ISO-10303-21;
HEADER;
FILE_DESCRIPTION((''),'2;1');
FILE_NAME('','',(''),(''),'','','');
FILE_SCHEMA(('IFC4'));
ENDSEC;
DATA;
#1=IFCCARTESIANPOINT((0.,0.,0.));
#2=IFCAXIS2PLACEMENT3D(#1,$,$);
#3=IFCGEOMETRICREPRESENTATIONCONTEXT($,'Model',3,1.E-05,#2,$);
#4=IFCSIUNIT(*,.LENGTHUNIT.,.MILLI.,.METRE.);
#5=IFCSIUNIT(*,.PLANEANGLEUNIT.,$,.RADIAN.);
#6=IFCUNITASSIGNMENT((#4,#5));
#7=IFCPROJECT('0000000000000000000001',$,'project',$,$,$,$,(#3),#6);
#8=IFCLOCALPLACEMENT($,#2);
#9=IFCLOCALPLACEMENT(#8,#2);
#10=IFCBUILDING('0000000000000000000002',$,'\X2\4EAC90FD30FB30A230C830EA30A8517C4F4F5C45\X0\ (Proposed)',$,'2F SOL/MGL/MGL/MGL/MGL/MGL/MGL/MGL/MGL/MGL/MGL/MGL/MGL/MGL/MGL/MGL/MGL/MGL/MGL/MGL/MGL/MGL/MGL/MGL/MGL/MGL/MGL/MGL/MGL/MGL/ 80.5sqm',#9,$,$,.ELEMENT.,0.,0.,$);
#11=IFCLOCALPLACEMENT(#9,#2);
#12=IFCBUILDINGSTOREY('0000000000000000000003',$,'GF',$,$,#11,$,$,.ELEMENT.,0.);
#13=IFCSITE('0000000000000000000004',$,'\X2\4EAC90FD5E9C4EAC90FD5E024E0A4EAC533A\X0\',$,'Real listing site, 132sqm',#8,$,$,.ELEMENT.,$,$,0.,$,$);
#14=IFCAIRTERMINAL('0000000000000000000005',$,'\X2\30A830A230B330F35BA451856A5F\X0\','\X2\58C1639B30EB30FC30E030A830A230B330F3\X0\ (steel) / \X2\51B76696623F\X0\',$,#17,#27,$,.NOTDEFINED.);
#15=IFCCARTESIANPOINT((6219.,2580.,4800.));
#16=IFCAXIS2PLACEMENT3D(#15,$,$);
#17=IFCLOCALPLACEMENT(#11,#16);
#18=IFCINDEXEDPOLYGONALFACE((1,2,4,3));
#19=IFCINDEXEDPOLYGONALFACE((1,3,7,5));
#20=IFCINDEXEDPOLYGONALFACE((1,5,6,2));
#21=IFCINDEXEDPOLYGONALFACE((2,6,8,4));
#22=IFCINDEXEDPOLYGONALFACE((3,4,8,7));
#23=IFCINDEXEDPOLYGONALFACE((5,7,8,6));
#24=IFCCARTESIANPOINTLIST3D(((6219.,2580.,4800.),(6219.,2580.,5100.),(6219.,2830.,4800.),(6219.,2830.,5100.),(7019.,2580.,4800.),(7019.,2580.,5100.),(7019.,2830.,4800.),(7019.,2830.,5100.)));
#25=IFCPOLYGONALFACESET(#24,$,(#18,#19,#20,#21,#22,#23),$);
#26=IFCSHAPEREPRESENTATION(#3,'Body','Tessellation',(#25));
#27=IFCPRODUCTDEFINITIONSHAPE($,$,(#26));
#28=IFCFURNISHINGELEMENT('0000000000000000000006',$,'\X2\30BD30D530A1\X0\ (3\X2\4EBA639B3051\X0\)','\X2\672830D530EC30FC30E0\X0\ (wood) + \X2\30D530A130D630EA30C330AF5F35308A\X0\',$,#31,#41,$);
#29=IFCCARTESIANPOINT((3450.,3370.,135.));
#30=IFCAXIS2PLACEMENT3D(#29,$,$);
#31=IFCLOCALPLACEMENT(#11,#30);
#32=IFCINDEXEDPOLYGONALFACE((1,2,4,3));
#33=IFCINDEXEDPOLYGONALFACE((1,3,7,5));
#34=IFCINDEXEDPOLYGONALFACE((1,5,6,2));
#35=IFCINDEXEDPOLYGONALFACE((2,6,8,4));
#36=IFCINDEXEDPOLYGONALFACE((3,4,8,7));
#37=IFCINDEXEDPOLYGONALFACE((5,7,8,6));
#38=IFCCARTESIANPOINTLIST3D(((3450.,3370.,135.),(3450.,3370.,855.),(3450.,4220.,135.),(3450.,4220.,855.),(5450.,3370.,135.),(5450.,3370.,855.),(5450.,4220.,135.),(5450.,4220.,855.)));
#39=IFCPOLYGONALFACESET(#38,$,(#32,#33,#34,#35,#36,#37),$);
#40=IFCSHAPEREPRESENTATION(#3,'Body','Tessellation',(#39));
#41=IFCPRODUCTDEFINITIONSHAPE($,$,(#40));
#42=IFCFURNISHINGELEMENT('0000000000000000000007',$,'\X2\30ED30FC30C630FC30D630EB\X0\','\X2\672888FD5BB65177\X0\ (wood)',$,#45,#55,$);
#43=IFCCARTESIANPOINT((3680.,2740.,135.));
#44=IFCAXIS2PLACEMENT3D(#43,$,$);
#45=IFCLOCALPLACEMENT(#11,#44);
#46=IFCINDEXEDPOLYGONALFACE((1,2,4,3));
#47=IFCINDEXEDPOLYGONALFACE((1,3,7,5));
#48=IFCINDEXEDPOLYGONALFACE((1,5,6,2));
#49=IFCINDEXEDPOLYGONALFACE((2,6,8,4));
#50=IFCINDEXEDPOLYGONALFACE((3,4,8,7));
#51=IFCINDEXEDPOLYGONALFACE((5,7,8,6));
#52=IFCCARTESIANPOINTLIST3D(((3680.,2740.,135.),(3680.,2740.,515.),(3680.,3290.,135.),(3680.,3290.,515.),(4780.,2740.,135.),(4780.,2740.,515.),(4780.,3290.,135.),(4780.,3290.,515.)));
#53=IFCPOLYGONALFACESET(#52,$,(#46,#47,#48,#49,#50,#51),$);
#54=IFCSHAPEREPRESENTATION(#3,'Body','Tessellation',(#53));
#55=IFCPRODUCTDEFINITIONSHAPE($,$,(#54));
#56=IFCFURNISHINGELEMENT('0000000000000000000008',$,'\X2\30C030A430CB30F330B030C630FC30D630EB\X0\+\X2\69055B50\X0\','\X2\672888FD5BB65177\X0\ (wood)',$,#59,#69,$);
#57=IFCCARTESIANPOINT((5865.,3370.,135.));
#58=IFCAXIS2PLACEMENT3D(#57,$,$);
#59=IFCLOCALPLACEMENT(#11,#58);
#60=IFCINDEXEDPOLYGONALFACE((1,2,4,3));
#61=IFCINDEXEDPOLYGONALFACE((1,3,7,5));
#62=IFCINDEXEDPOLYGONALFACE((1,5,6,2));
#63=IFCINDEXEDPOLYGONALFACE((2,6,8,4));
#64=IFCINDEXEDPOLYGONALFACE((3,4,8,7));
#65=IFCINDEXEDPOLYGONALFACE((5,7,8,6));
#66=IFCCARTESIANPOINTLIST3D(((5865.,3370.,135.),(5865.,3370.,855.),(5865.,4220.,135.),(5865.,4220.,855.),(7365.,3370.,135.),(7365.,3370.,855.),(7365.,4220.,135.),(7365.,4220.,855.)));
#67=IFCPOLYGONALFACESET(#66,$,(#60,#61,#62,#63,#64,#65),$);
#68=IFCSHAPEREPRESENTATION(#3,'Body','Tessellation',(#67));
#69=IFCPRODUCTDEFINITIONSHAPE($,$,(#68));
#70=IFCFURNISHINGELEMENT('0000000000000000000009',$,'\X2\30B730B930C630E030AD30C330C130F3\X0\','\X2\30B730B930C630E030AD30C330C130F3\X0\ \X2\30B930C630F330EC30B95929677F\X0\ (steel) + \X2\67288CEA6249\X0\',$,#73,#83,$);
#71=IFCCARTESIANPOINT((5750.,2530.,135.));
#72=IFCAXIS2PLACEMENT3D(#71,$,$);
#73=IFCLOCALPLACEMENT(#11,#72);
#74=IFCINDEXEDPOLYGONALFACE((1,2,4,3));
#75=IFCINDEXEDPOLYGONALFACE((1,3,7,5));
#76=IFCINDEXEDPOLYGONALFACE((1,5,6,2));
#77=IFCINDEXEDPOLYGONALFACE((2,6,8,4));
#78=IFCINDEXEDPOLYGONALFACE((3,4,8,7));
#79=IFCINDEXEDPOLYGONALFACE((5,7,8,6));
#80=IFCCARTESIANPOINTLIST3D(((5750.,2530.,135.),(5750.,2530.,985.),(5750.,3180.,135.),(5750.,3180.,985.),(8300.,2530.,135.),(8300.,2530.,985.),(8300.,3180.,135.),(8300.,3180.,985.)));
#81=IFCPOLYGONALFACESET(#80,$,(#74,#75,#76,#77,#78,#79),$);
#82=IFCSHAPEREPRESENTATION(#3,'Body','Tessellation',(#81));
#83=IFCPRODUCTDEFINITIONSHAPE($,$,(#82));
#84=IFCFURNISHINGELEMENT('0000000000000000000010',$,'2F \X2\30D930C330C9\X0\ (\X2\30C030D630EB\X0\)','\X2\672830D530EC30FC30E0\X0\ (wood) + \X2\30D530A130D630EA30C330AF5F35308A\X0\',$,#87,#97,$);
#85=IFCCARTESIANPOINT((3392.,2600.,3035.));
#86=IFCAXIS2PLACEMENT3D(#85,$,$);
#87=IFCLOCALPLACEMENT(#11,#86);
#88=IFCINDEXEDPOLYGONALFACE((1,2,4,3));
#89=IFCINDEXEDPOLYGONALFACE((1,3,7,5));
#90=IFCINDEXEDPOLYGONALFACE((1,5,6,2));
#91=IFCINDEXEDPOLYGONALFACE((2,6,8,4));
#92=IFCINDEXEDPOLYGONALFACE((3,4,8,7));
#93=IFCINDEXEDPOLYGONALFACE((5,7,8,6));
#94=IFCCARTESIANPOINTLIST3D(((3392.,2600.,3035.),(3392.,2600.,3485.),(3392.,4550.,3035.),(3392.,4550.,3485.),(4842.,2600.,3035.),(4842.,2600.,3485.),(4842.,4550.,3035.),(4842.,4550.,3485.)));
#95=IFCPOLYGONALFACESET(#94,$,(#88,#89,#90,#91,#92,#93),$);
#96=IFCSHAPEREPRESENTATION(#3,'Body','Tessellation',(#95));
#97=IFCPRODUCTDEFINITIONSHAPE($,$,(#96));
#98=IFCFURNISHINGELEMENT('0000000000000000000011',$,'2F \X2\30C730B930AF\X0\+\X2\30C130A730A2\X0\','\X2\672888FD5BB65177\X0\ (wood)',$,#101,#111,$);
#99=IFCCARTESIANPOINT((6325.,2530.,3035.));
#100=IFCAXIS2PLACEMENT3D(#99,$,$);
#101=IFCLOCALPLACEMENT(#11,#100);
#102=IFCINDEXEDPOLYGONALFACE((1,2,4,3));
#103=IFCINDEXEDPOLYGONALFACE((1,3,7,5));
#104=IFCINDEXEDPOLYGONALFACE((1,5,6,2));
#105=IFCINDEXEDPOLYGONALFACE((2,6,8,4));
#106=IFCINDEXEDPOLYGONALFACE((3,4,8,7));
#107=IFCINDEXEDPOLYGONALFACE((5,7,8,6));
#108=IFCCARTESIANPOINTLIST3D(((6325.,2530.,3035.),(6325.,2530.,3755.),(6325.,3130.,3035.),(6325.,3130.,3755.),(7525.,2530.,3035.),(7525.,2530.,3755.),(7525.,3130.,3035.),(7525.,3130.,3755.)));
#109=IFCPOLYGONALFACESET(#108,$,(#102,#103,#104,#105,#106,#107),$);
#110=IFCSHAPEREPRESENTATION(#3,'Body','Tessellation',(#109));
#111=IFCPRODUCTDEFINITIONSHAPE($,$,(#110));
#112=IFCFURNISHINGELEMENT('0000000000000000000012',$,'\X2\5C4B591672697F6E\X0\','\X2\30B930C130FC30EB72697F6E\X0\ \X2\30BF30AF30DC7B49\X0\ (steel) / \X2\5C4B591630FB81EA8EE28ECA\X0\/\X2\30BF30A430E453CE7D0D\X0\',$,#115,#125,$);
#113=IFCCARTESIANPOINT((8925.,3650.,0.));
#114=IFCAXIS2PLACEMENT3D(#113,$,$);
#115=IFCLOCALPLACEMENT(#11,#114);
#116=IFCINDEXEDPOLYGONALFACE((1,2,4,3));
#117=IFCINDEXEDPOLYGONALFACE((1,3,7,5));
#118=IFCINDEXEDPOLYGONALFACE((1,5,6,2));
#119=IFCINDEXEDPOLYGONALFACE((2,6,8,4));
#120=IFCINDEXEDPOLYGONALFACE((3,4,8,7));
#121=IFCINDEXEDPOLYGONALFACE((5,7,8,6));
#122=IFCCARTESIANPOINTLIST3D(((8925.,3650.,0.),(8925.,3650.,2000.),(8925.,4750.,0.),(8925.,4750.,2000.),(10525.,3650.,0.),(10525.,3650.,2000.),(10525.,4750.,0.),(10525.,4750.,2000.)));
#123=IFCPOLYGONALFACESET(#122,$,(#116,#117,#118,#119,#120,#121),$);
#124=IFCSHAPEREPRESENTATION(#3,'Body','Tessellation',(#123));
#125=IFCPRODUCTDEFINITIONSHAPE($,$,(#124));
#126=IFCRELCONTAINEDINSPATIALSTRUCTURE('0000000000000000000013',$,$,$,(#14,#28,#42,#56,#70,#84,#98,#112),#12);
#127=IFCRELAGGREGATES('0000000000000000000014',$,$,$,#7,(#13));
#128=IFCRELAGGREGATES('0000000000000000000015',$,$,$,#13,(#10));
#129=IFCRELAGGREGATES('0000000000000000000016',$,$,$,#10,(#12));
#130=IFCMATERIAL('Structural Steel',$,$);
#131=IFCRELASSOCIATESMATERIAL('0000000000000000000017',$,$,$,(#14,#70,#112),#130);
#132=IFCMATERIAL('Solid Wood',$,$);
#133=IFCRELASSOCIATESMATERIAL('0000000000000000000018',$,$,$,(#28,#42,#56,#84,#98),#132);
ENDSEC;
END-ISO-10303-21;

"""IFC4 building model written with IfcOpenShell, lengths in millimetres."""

from ifc_helpers import new_model, si_unit, frame, frame_2d, origin, place, context, project, spatial, rectangle, extrude, material, element, save


model = new_model("IFC4")

# Units and contexts
model_context = context("Model", 3, precision=1e-05, world=origin())
ifc_project = project(units=[si_unit("LENGTHUNIT", "METRE", prefix="MILLI"), si_unit("PLANEANGLEUNIT", "RADIAN")], contexts=[model_context])

# Site, building, storey
site_placement = place(None, origin())
site = spatial("IfcSite", under=ifc_project, at=site_placement, Name="京都府京都市上京区", ObjectType="Real listing site, 132sqm", CompositionType="ELEMENT", RefElevation=0.0)
building_placement = place(site_placement, origin())
building = spatial("IfcBuilding", under=site, at=building_placement, Name="京都・アトリエ兼住居 (Proposed)", ObjectType="2F SOL/MGL/MGL/MGL/MGL/MGL/MGL/MGL/MGL/MGL/MGL/MGL/MGL/MGL/MGL/MGL/MGL/MGL/MGL/MGL/MGL/MGL/MGL/MGL/MGL/MGL/MGL/MGL/MGL/MGL/ 80.5sqm", CompositionType="ELEMENT", ElevationOfRefHeight=0.0, ElevationOfTerrain=0.0)
storey_placement = place(building_placement, origin())
storey = spatial("IfcBuildingStorey", under=building, at=storey_placement, Name="GF", CompositionType="ELEMENT", Elevation=0.0)

# Shared definitions
ifc_material_1 = material(Name="Solid Wood")

# Shared definitions
ifc_material_2 = material(Name="Structural Steel")

# Air terminal
air_terminal_1_placement = place(storey_placement, frame((6219.0, 2580.0, 4800.0)))
element("IfcAirTerminal", 1, at=air_terminal_1_placement, inside=storey, material=ifc_material_2, Name="エアコン室内機", Description="壁掛ルームエアコン (steel) / 冷暖房", PredefinedType="NOTDEFINED", context=model_context, shape_type="SweptSolid", body=[
    extrude(rectangle(XDim=800.0, YDim=250.0, at=frame_2d((400.0, 125.0))), frame((6219.0, 2580.0, 4800.0)), (0.0, 0.0, 1.0), 300.0),
])

# Furnishing elements
furnishing_1_placement = place(storey_placement, frame((3450.0, 3370.0, 135.0)))
element("IfcFurnishingElement", 2, at=furnishing_1_placement, inside=storey, material=ifc_material_1, Name="ソファ (3人掛け)", Description="木フレーム (wood) + ファブリック張り", context=model_context, shape_type="SweptSolid", body=[
    extrude(rectangle(XDim=2000.0, YDim=850.0, at=frame_2d((1000.0, 425.0))), frame((3450.0, 3370.0, 135.0)), (0.0, 0.0, 1.0), 720.0),
])
furnishing_2_placement = place(storey_placement, frame((3680.0, 2740.0, 135.0)))
element("IfcFurnishingElement", 3, at=furnishing_2_placement, inside=storey, material=ifc_material_1, Name="ローテーブル", Description="木製家具 (wood)", context=model_context, shape_type="SweptSolid", body=[
    extrude(rectangle(XDim=1100.0, YDim=550.0, at=frame_2d((550.0, 275.0))), frame((3680.0, 2740.0, 135.0)), (0.0, 0.0, 1.0), 380.0),
])
furnishing_3_placement = place(storey_placement, frame((5865.0, 3370.0, 135.0)))
element("IfcFurnishingElement", 4, at=furnishing_3_placement, inside=storey, material=ifc_material_1, Name="ダイニングテーブル+椅子", Description="木製家具 (wood)", context=model_context, shape_type="SweptSolid", body=[
    extrude(rectangle(XDim=1500.0, YDim=850.0, at=frame_2d((750.0, 425.0))), frame((5865.0, 3370.0, 135.0)), (0.0, 0.0, 1.0), 720.0),
])
furnishing_4_placement = place(storey_placement, frame((5750.0, 2530.0, 135.0)))
element("IfcFurnishingElement", 5, at=furnishing_4_placement, inside=storey, material=ifc_material_2, Name="システムキッチン", Description="システムキッチン ステンレス天板 (steel) + 木質扉", context=model_context, shape_type="SweptSolid", body=[
    extrude(rectangle(XDim=2550.0, YDim=650.0, at=frame_2d((1275.0, 325.0))), frame((5750.0, 2530.0, 135.0)), (0.0, 0.0, 1.0), 850.0),
])
furnishing_5_placement = place(storey_placement, frame((3392.0, 2600.0, 3035.0)))
element("IfcFurnishingElement", 6, at=furnishing_5_placement, inside=storey, material=ifc_material_1, Name="2F ベッド (ダブル)", Description="木フレーム (wood) + ファブリック張り", context=model_context, shape_type="SweptSolid", body=[
    extrude(rectangle(XDim=1450.0, YDim=1950.0, at=frame_2d((725.0, 975.0))), frame((3392.0, 2600.0, 3035.0)), (0.0, 0.0, 1.0), 450.0),
])
furnishing_6_placement = place(storey_placement, frame((6325.0, 2530.0, 3035.0)))
element("IfcFurnishingElement", 7, at=furnishing_6_placement, inside=storey, material=ifc_material_1, Name="2F デスク+チェア", Description="木製家具 (wood)", context=model_context, shape_type="SweptSolid", body=[
    extrude(rectangle(XDim=1200.0, YDim=600.0, at=frame_2d((600.0, 300.0))), frame((6325.0, 2530.0, 3035.0)), (0.0, 0.0, 1.0), 720.0),
])
furnishing_7_placement = place(storey_placement, frame((8925.0, 3650.0, 0.0)))
element("IfcFurnishingElement", 8, at=furnishing_7_placement, inside=storey, material=ifc_material_2, Name="屋外物置", Description="スチール物置 タクボ等 (steel) / 屋外・自転車/タイヤ収納", context=model_context, shape_type="SweptSolid", body=[
    extrude(rectangle(XDim=1600.0, YDim=1100.0, at=frame_2d((800.0, 550.0))), frame((8925.0, 3650.0, 0.0)), (0.0, 0.0, 1.0), 2000.0),
])

save(model, "model.ifc")
